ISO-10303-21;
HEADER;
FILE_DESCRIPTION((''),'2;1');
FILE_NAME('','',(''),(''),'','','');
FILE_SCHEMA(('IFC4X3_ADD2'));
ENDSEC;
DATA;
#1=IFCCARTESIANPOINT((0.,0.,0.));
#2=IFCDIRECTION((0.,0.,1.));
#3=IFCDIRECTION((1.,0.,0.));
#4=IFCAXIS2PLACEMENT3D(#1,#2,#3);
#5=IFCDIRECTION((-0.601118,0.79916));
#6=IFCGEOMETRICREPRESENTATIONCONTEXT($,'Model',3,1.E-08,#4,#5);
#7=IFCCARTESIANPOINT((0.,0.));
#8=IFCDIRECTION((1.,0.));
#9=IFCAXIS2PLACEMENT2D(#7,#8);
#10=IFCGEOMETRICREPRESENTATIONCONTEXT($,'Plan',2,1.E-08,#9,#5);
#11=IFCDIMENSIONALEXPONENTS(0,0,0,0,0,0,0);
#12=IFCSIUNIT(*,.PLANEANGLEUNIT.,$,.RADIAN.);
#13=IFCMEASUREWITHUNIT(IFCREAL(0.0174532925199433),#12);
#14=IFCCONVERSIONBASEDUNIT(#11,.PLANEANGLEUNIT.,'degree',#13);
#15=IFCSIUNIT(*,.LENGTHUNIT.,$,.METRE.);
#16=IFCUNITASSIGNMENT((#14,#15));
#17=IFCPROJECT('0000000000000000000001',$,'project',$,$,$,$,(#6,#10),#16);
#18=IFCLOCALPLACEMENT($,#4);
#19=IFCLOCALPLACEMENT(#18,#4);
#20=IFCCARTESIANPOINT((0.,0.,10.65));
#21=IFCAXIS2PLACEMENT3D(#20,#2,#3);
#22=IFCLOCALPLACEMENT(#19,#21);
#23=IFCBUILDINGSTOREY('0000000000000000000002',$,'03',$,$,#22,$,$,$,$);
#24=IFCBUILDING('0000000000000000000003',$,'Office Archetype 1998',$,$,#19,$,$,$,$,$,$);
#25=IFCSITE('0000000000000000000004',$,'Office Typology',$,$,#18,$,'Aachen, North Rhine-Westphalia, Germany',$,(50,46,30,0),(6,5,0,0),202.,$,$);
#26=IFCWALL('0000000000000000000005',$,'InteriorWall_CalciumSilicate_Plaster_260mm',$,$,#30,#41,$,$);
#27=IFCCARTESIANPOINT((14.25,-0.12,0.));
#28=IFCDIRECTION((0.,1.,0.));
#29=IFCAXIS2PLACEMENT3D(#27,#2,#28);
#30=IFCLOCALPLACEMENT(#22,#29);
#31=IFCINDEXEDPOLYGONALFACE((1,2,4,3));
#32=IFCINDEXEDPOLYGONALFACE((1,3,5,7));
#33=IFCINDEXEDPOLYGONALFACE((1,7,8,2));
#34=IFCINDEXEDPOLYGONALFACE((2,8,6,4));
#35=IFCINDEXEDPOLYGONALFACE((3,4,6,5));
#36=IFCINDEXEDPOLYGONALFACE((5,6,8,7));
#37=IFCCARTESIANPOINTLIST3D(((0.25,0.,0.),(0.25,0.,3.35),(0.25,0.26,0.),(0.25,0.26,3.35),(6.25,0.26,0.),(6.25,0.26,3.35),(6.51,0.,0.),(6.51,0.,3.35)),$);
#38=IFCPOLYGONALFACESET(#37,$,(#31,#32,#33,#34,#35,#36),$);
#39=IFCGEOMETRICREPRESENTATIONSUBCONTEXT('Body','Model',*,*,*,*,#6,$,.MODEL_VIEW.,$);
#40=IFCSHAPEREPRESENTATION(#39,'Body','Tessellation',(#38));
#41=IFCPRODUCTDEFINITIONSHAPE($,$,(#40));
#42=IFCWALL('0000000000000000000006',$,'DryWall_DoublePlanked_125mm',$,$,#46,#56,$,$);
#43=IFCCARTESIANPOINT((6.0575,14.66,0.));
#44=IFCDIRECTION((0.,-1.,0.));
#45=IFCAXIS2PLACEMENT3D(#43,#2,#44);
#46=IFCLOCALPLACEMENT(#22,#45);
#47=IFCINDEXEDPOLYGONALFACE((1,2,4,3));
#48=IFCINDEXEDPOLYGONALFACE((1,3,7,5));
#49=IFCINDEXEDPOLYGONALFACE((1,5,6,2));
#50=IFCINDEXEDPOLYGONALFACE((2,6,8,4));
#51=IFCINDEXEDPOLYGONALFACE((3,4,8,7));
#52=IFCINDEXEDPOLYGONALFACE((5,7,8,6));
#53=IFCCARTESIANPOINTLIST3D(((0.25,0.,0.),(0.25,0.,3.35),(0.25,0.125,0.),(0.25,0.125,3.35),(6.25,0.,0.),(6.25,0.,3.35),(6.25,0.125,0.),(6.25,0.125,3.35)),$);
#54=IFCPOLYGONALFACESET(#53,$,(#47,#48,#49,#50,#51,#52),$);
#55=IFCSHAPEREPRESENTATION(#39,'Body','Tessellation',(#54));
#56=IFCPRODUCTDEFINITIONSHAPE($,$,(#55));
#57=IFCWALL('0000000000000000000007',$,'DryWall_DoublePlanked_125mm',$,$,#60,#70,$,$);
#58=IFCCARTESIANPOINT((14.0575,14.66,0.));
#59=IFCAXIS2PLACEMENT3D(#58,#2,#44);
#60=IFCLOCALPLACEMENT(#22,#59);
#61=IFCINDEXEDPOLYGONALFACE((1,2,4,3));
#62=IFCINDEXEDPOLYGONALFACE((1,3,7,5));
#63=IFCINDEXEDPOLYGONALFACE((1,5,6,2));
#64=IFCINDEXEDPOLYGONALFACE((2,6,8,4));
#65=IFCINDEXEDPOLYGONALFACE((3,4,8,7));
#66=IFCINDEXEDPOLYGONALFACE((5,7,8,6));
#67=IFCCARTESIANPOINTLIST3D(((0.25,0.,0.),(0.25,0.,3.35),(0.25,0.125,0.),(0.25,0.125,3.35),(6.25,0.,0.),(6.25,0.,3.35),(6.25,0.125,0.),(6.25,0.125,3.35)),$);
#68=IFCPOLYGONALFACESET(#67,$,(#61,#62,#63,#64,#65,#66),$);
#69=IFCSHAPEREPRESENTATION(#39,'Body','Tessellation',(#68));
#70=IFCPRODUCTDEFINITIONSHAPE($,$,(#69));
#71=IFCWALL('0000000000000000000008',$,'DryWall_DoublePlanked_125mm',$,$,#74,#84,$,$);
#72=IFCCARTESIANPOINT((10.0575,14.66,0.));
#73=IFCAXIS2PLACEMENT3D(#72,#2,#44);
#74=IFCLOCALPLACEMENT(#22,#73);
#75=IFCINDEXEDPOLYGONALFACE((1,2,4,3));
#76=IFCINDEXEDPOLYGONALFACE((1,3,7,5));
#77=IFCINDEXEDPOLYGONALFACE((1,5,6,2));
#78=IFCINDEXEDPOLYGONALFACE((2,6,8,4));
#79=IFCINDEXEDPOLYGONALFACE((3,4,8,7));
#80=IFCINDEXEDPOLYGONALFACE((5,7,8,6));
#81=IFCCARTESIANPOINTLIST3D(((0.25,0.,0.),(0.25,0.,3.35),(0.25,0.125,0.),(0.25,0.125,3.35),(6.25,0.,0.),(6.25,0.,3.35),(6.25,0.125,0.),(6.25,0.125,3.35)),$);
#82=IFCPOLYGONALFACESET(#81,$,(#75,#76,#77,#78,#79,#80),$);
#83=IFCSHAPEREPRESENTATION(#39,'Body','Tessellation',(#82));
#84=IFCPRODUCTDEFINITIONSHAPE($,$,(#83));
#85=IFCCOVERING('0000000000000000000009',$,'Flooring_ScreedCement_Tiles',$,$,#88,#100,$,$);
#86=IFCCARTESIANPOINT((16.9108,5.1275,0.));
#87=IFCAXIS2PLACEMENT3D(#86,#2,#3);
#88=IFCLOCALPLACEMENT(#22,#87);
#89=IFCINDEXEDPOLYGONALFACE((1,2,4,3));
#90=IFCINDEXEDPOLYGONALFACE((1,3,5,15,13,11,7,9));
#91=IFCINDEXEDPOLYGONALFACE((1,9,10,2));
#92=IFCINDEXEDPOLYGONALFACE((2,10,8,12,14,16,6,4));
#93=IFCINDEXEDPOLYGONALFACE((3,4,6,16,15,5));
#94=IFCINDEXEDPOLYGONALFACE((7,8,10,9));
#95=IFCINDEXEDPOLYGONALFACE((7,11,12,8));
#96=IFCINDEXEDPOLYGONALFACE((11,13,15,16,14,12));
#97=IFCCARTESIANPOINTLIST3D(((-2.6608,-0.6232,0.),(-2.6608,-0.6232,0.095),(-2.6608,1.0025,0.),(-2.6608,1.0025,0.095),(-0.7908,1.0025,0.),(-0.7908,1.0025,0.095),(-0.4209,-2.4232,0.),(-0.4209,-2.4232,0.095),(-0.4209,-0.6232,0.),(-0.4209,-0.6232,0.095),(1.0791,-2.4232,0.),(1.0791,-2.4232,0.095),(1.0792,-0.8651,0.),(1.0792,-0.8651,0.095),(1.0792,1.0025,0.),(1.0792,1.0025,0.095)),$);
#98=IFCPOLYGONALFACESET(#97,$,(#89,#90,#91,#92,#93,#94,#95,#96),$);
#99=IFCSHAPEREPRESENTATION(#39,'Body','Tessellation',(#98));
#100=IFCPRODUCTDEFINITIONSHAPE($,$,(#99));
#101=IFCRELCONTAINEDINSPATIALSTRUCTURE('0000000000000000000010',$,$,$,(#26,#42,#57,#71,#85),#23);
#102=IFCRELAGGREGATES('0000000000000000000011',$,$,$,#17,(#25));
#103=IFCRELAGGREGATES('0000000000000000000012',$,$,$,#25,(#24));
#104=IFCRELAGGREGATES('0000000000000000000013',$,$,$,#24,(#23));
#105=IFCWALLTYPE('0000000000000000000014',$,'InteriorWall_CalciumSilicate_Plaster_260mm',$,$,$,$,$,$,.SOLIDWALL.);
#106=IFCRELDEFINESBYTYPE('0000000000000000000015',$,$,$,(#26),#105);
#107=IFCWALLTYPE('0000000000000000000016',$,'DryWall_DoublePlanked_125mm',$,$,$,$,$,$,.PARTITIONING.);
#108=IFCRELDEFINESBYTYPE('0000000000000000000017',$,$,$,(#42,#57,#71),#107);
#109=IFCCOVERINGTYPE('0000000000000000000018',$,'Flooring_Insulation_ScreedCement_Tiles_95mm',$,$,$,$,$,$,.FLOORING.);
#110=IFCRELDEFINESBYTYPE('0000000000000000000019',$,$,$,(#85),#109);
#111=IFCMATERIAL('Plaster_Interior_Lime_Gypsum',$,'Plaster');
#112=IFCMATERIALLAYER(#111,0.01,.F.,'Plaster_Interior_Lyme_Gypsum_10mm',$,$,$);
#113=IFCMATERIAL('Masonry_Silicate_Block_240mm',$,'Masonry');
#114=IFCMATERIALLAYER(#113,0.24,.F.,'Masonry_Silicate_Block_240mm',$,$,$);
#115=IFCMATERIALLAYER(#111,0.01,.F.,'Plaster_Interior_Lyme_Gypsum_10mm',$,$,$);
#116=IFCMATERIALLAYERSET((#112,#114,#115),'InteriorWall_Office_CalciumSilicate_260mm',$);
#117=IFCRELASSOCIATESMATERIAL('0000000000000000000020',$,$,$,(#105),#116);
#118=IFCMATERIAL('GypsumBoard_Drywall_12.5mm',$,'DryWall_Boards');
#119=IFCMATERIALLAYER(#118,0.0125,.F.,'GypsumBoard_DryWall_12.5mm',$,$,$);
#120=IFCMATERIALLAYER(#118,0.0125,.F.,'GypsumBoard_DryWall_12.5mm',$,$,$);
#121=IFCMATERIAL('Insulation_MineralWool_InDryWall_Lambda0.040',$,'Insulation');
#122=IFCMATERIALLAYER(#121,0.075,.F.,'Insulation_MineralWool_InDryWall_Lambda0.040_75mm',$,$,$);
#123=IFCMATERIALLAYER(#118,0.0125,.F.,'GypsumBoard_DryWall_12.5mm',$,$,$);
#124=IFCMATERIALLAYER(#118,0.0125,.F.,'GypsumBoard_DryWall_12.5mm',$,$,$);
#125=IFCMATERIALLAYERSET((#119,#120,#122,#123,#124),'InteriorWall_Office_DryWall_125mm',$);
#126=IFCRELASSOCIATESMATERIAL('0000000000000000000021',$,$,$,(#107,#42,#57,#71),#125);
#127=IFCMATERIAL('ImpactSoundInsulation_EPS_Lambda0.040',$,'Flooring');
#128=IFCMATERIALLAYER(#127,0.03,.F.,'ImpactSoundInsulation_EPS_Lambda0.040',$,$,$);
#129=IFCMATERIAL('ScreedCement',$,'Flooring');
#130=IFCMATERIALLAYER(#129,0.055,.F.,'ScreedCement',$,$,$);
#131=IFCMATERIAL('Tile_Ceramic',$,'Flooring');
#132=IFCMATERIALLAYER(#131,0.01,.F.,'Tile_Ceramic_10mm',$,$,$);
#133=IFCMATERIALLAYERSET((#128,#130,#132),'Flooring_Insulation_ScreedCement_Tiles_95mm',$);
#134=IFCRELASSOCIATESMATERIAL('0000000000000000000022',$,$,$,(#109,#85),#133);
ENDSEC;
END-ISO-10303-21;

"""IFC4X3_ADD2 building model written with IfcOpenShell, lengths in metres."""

from ifc_helpers import new_model, entity, si_unit, converted_unit, direction, frame, origin_with_axes, origin_2d_with_axis, place, context, subcontext, project, spatial, line, indexed_curve, outline, extrude, material, layer, layer_set, layer_usage, type_object, element, save


model = new_model("IFC4X3_ADD2")

# Units and contexts
model_context = context("Model", 3, precision=1e-08, world=origin_with_axes(), true_north=direction((-0.601118, 0.79916)))
plan_context = context("Plan", 2, precision=1e-08, world=origin_2d_with_axis(), true_north=direction((-0.601118, 0.79916)))
body_context = subcontext(model_context, "Body", "Model", "MODEL_VIEW")
ifc_project = project(units=[converted_unit("PLANEANGLEUNIT", "degree", entity("IfcReal", 0.0174532925199433), si_unit("PLANEANGLEUNIT", "RADIAN"), dimensions=[0, 0, 0, 0, 0, 0, 0]), si_unit("LENGTHUNIT", "METRE")], contexts=[model_context, plan_context])

# Site, building, storey
site_placement = place(None, origin_with_axes())
site = spatial("IfcSite", under=ifc_project, at=site_placement, Name="Office Typology", LongName="Aachen, North Rhine-Westphalia, Germany", RefLatitude=(50, 46, 30, 0), RefLongitude=(6, 5, 0, 0), RefElevation=202.0)
building_placement = place(site_placement, origin_with_axes())
building = spatial("IfcBuilding", under=site, at=building_placement, Name="Office Archetype 1998")
storey_placement = place(building_placement, frame((0.0, 0.0, 10.65), z_axis=(0.0, 0.0, 1.0), x_axis=(1.0, 0.0, 0.0)))
storey = spatial("IfcBuildingStorey", under=building, at=storey_placement, Name="03")

# Shared definitions
ifc_material_1 = material(Name="Plaster_Interior_Lime_Gypsum", Category="Plaster")
ifc_layer_1 = layer(ifc_material_1, 0.01, ventilated=False, Name="Plaster_Interior_Lyme_Gypsum_10mm")
ifc_material_2 = material(Name="Masonry_Silicate_Block_240mm", Category="Masonry")
ifc_layer_2 = layer(ifc_material_2, 0.24, ventilated=False, Name="Masonry_Silicate_Block_240mm")
ifc_layer_3 = layer(ifc_material_1, 0.01, ventilated=False, Name="Plaster_Interior_Lyme_Gypsum_10mm")
ifc_layer_set_1 = layer_set([ifc_layer_1, ifc_layer_2, ifc_layer_3], Name="InteriorWall_Office_CalciumSilicate_260mm")
wall_type_1 = type_object("IfcWallType", Name="InteriorWall_CalciumSilicate_Plaster_260mm", PredefinedType="SOLIDWALL", material=ifc_layer_set_1)

# Wall
wall_1_placement = place(storey_placement, frame((14.25, -0.12, 0.0), z_axis=(0.0, 0.0, 1.0), x_axis=(0.0, 1.0, 0.0)))
element("IfcWall", 1, at=wall_1_placement, inside=storey, type_object=wall_type_1, Name="InteriorWall_CalciumSilicate_Plaster_260mm", context=body_context, shape_type="SweptSolid", body=[
    extrude(outline(indexed_curve([(0.25, 0.0), (0.25, 0.26), (6.25, 0.26), (6.51, 0.0)], segments=[line(1, 2, 3, 4, 1)])), origin_with_axes(), (0.0, 0.0, 1.0), 3.35),
])

# Walls
ifc_material_3 = material(Name="GypsumBoard_Drywall_12.5mm", Category="DryWall_Boards")
ifc_layer_4 = layer(ifc_material_3, 0.0125, ventilated=False, Name="GypsumBoard_DryWall_12.5mm")
ifc_layer_5 = layer(ifc_material_3, 0.0125, ventilated=False, Name="GypsumBoard_DryWall_12.5mm")
ifc_material_4 = material(Name="Insulation_MineralWool_InDryWall_Lambda0.040", Category="Insulation")
ifc_layer_6 = layer(ifc_material_4, 0.075, ventilated=False, Name="Insulation_MineralWool_InDryWall_Lambda0.040_75mm")
ifc_layer_7 = layer(ifc_material_3, 0.0125, ventilated=False, Name="GypsumBoard_DryWall_12.5mm")
ifc_layer_8 = layer(ifc_material_3, 0.0125, ventilated=False, Name="GypsumBoard_DryWall_12.5mm")
ifc_layer_set_2 = layer_set([ifc_layer_4, ifc_layer_5, ifc_layer_6, ifc_layer_7, ifc_layer_8], Name="InteriorWall_Office_DryWall_125mm")
ifc_layer_usage_1 = layer_usage(ifc_layer_set_2, "AXIS2", "POSITIVE", 0.0)
wall_type_2 = type_object("IfcWallType", Name="DryWall_DoublePlanked_125mm", PredefinedType="PARTITIONING", material=ifc_layer_set_2)
wall_2_placement = place(storey_placement, frame((6.0575, 14.66, 0.0), z_axis=(0.0, 0.0, 1.0), x_axis=(0.0, -1.0, 0.0)))
element("IfcWall", 2, at=wall_2_placement, inside=storey, type_object=wall_type_2, material=ifc_layer_usage_1, Name="DryWall_DoublePlanked_125mm", context=body_context, shape_type="SweptSolid", body=[
    extrude(outline(indexed_curve([(0.25, 0.0), (0.25, 0.125), (6.25, 0.125), (6.25, 0.0)], segments=[line(1, 2, 3, 4, 1)])), origin_with_axes(), (0.0, 0.0, 1.0), 3.35),
])
ifc_layer_usage_2 = layer_usage(ifc_layer_set_2, "AXIS2", "POSITIVE", 0.0)
wall_3_placement = place(storey_placement, frame((14.0575, 14.66, 0.0), z_axis=(0.0, 0.0, 1.0), x_axis=(0.0, -1.0, 0.0)))
element("IfcWall", 3, at=wall_3_placement, inside=storey, type_object=wall_type_2, material=ifc_layer_usage_2, Name="DryWall_DoublePlanked_125mm", context=body_context, shape_type="SweptSolid", body=[
    extrude(outline(indexed_curve([(0.25, 0.0), (0.25, 0.125), (6.25, 0.125), (6.25, 0.0)], segments=[line(1, 2, 3, 4, 1)])), origin_with_axes(), (0.0, 0.0, 1.0), 3.35),
])
ifc_layer_usage_3 = layer_usage(ifc_layer_set_2, "AXIS2", "POSITIVE", 0.0)
wall_4_placement = place(storey_placement, frame((10.0575, 14.66, 0.0), z_axis=(0.0, 0.0, 1.0), x_axis=(0.0, -1.0, 0.0)))
element("IfcWall", 4, at=wall_4_placement, inside=storey, type_object=wall_type_2, material=ifc_layer_usage_3, Name="DryWall_DoublePlanked_125mm", context=body_context, shape_type="SweptSolid", body=[
    extrude(outline(indexed_curve([(0.25, 0.0), (0.25, 0.125), (6.25, 0.125), (6.25, 0.0)], segments=[line(1, 2, 3, 4, 1)])), origin_with_axes(), (0.0, 0.0, 1.0), 3.35),
])

# Covering
ifc_material_5 = material(Name="ImpactSoundInsulation_EPS_Lambda0.040", Category="Flooring")
ifc_layer_9 = layer(ifc_material_5, 0.03, ventilated=False, Name="ImpactSoundInsulation_EPS_Lambda0.040")
ifc_material_6 = material(Name="ScreedCement", Category="Flooring")
ifc_layer_10 = layer(ifc_material_6, 0.055, ventilated=False, Name="ScreedCement")
ifc_material_7 = material(Name="Tile_Ceramic", Category="Flooring")
ifc_layer_11 = layer(ifc_material_7, 0.01, ventilated=False, Name="Tile_Ceramic_10mm")
ifc_layer_set_3 = layer_set([ifc_layer_9, ifc_layer_10, ifc_layer_11], Name="Flooring_Insulation_ScreedCement_Tiles_95mm")
ifc_layer_usage_4 = layer_usage(ifc_layer_set_3, "AXIS3", "POSITIVE", 0.0)
covering_type = type_object("IfcCoveringType", Name="Flooring_Insulation_ScreedCement_Tiles_95mm", PredefinedType="FLOORING", material=ifc_layer_set_3)
covering_placement = place(storey_placement, frame((16.9108, 5.1275, 0.0), z_axis=(0.0, 0.0, 1.0), x_axis=(1.0, 0.0, 0.0)))
element("IfcCovering", 5, at=covering_placement, inside=storey, type_object=covering_type, material=ifc_layer_usage_4, Name="Flooring_ScreedCement_Tiles", context=body_context, shape_type="SweptSolid", body=[
    extrude(outline(indexed_curve([(-0.7908, 1.0025), (-2.6608, 1.0025), (-2.6608, -0.6232), (-0.4209, -0.6232), (-0.4209, -2.4232), (1.0791, -2.4232), (1.0792, -0.8651), (1.0792, 1.0025), (-0.7908, 1.0025)])), None, (0.0, 0.0, 1.0), 0.095),
])

save(model, "model.ifc")
